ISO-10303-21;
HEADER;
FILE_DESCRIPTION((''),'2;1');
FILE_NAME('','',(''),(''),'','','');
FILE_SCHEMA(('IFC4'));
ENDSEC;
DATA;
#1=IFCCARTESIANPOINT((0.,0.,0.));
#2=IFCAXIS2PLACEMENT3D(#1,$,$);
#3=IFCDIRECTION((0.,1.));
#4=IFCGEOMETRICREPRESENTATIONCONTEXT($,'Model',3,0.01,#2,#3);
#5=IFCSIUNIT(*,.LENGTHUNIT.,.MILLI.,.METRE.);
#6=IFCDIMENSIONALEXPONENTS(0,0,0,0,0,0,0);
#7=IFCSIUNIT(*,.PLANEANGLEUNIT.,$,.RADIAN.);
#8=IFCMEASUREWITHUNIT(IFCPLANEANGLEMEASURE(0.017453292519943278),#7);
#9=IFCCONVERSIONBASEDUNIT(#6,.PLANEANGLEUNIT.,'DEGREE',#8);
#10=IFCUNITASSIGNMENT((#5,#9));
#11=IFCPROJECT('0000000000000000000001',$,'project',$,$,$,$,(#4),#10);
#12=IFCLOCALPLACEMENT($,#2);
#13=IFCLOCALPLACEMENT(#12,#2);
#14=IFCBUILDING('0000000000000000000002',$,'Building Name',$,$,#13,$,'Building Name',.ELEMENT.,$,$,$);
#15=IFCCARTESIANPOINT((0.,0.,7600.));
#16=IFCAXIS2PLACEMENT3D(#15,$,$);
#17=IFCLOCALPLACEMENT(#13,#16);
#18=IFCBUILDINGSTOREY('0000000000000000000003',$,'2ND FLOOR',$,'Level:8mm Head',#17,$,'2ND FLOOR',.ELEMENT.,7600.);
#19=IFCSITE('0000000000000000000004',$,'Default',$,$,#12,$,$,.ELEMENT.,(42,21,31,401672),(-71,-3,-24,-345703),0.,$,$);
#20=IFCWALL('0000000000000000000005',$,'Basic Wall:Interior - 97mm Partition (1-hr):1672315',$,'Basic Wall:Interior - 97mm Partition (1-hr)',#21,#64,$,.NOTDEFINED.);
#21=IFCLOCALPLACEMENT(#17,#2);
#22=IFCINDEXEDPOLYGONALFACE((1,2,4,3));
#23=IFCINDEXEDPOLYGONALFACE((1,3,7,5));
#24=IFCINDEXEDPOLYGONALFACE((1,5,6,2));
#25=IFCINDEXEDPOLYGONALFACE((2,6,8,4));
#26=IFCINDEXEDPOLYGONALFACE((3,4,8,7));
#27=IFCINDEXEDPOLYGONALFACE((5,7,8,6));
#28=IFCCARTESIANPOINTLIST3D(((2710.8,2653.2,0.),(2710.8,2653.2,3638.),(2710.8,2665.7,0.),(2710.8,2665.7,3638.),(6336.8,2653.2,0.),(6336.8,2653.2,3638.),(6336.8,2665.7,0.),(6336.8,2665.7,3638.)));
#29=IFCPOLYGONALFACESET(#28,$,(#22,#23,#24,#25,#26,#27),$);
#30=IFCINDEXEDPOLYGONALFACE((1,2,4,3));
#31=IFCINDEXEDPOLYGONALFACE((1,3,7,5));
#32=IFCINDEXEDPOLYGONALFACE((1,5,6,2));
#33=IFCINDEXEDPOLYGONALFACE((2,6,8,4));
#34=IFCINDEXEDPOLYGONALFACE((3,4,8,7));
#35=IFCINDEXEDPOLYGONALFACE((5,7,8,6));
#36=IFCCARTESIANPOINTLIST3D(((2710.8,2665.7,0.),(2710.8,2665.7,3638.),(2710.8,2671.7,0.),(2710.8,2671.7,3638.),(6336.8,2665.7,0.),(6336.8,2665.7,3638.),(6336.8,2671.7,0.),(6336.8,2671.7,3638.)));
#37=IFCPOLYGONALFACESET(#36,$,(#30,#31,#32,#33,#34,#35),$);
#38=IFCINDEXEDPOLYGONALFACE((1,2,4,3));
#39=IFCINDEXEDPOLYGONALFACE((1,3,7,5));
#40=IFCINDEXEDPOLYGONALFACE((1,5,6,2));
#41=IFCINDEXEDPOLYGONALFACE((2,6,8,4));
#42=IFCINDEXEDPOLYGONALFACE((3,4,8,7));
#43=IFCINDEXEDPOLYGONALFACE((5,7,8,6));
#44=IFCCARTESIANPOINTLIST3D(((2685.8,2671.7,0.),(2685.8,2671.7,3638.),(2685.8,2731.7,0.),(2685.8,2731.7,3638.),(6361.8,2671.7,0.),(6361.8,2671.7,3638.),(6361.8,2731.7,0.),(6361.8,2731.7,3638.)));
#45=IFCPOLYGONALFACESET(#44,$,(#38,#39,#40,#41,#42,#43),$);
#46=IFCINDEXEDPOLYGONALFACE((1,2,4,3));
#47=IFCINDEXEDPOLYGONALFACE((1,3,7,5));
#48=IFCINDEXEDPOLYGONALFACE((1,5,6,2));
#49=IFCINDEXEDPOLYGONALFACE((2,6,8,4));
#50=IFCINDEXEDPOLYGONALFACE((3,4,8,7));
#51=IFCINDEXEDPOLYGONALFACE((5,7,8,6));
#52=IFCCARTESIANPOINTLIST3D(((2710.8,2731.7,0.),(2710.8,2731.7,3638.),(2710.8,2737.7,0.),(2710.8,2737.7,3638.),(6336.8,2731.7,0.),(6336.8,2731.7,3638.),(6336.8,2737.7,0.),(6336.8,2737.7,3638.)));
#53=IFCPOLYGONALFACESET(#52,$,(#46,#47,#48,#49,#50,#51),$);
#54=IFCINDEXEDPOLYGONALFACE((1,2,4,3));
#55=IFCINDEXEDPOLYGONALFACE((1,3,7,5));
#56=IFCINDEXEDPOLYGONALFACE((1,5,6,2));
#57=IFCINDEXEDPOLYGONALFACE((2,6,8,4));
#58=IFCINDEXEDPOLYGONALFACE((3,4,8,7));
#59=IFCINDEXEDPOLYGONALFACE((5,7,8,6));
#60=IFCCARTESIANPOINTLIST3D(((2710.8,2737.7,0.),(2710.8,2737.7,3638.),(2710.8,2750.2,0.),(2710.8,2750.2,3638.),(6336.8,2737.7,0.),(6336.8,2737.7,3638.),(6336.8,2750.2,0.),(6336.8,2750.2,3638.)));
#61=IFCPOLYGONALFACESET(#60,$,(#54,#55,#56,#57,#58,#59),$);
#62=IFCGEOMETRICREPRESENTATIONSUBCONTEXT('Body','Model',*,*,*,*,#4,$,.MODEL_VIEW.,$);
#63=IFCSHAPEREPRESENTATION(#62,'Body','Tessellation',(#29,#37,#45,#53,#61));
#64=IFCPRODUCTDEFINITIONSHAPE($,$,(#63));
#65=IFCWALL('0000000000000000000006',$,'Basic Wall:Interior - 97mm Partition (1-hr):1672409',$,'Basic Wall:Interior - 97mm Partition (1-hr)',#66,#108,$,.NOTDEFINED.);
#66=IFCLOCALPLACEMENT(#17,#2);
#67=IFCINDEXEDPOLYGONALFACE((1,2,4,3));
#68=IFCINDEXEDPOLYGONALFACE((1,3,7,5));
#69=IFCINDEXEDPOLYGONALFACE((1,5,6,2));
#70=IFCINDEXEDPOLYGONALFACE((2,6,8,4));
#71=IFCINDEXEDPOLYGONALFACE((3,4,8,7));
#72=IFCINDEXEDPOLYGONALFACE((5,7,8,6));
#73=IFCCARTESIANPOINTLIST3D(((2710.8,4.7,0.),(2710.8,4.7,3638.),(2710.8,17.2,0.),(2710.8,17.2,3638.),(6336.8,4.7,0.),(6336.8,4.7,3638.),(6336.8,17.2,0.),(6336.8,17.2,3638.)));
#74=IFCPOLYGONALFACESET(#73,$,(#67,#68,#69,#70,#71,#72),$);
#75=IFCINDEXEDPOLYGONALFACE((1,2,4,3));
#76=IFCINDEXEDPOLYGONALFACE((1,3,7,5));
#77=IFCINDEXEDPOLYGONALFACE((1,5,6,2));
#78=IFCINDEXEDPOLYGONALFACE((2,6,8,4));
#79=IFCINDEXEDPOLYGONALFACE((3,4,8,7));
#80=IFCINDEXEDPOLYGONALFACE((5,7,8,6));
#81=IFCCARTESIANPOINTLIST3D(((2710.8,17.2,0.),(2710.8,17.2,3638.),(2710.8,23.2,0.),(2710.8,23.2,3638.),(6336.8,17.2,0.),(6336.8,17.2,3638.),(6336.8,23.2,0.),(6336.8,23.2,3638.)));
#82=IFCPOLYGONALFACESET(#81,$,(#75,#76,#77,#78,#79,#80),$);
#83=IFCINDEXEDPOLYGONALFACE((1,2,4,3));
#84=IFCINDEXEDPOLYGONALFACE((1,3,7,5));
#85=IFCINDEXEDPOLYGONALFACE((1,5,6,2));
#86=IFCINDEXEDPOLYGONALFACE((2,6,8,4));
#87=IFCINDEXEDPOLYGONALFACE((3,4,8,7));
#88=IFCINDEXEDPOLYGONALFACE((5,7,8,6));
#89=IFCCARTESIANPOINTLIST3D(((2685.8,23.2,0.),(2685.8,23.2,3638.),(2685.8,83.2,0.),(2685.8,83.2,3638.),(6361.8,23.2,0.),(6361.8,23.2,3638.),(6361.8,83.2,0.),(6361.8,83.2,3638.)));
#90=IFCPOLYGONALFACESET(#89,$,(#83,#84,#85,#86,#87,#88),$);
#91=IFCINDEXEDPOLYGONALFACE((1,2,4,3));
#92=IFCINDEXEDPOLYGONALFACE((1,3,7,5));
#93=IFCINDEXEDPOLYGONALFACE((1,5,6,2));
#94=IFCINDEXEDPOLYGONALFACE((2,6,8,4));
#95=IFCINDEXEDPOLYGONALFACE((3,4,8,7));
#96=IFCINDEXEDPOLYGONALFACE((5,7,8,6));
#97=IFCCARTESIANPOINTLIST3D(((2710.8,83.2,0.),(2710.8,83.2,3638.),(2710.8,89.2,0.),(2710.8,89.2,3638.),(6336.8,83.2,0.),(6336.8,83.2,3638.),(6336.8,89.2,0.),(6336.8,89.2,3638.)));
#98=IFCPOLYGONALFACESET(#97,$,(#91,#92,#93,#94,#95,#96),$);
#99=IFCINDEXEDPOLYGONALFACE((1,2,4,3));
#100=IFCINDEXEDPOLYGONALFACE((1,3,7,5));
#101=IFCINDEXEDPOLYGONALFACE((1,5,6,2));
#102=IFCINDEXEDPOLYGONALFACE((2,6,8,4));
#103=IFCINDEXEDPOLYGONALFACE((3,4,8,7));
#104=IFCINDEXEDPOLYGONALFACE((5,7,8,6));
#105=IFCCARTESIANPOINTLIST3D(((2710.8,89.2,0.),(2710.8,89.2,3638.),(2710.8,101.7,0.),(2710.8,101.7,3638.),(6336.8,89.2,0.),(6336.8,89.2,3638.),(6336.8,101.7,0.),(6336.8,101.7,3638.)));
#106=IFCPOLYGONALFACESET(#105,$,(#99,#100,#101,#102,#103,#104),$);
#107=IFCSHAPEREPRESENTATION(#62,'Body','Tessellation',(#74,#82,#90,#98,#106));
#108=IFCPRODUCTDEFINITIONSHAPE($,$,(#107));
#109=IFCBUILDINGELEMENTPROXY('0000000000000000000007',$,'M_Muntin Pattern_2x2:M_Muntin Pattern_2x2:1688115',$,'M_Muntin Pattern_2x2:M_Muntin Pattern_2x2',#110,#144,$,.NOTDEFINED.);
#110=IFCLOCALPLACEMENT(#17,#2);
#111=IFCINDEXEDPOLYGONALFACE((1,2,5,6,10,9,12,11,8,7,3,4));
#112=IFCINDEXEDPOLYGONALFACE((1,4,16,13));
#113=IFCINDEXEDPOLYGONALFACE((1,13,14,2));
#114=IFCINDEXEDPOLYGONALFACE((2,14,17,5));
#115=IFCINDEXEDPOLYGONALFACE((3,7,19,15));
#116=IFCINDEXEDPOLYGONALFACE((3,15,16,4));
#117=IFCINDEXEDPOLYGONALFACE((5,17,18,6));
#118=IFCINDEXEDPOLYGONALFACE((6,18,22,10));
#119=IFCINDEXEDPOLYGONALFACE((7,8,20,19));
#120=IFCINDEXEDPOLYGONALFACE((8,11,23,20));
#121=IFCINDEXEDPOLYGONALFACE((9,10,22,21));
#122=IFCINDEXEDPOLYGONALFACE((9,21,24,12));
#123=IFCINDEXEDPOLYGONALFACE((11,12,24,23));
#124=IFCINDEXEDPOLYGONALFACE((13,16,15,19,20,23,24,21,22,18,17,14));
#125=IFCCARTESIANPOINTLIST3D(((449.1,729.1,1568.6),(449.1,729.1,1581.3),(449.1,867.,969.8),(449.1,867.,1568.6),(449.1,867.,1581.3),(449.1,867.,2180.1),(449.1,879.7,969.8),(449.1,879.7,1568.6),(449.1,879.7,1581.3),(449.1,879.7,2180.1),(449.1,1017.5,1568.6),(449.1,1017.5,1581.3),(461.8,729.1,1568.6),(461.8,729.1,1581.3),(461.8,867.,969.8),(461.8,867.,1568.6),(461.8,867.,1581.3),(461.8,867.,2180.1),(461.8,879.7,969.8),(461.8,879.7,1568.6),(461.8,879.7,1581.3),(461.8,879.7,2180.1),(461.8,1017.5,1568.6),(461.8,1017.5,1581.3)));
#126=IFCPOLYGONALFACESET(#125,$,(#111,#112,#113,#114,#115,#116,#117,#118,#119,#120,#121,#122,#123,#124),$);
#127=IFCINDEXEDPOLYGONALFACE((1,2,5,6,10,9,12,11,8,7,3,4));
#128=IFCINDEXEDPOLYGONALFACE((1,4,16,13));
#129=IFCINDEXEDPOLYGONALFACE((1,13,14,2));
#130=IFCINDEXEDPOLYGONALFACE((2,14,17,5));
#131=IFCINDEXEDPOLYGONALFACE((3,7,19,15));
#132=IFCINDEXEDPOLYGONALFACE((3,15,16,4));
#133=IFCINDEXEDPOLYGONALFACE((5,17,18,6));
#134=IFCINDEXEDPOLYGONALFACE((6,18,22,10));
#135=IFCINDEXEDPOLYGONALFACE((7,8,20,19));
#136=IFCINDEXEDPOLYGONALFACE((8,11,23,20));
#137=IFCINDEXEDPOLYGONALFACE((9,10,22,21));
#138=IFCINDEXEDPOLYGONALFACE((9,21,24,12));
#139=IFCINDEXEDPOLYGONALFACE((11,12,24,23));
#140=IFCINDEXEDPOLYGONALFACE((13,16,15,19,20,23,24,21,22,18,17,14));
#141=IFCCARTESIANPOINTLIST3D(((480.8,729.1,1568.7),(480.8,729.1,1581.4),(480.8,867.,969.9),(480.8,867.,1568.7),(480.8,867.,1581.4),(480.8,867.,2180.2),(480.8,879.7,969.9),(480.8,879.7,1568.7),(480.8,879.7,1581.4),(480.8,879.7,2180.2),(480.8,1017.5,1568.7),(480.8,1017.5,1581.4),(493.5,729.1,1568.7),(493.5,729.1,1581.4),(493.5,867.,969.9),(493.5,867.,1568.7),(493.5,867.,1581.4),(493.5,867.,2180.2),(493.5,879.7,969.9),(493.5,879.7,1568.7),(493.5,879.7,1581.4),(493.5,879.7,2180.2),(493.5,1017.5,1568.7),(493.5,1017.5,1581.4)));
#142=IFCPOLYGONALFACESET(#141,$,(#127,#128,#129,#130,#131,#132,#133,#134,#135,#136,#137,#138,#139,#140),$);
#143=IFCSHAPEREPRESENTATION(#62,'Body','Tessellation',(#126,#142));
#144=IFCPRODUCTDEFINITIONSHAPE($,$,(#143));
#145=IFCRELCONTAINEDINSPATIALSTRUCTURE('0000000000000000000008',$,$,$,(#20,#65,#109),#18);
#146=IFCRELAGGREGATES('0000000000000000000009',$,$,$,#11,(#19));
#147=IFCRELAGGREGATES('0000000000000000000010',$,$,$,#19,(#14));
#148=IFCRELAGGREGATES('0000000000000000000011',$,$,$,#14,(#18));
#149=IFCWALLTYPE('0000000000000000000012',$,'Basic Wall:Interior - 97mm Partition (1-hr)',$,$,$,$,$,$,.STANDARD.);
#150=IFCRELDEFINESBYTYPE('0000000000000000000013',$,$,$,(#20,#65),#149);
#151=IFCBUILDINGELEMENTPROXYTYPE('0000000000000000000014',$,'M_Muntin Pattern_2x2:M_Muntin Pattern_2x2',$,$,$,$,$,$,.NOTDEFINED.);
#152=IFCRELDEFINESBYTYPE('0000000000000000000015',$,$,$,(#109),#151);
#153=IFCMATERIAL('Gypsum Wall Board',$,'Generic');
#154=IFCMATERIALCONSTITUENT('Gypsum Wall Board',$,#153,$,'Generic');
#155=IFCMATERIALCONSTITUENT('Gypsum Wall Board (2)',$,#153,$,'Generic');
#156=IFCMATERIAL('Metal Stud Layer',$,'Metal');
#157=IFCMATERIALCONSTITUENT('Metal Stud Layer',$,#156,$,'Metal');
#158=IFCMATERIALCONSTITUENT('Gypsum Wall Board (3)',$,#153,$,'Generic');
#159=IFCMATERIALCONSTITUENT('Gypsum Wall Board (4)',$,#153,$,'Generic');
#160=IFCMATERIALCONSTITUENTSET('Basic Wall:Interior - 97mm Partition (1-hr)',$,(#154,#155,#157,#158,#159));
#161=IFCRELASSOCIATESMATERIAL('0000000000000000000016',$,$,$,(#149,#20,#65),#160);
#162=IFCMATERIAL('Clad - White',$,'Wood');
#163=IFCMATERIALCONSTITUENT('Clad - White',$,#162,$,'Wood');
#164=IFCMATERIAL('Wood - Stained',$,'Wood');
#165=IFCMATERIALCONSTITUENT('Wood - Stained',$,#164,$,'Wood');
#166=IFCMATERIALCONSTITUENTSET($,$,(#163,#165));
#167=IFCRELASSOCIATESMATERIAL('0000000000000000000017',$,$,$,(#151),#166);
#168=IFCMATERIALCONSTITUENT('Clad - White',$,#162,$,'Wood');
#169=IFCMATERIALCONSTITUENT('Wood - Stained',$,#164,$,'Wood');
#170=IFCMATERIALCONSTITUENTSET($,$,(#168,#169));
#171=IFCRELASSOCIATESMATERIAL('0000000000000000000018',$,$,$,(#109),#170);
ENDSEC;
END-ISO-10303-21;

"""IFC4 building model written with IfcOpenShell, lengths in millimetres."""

from ifc_helpers import new_model, entity, si_unit, converted_unit, direction, frame, origin, place, context, subcontext, project, spatial, indexed_curve, outline, extrude, source, transform, mapped, material, constituent, constituent_set, type_object, type_shapes, element, save


model = new_model("IFC4")

# Units and contexts
model_context = context("Model", 3, precision=0.01, world=origin(), true_north=direction((0.0, 1.0)))
body_context = subcontext(model_context, "Body", "Model", "MODEL_VIEW")
ifc_project = project(units=[si_unit("LENGTHUNIT", "METRE", prefix="MILLI"), converted_unit("PLANEANGLEUNIT", "DEGREE", entity("IfcPlaneAngleMeasure", 0.017453292519943278), si_unit("PLANEANGLEUNIT", "RADIAN"), dimensions=[0, 0, 0, 0, 0, 0, 0])], contexts=[model_context])

# Site, building, storey
site_placement = place(None, origin())
site = spatial("IfcSite", under=ifc_project, at=site_placement, Name="Default", CompositionType="ELEMENT", RefLatitude=(42, 21, 31, 401672), RefLongitude=(-71, -3, -24, -345703), RefElevation=0.0)
building_placement = place(site_placement, origin())
building = spatial("IfcBuilding", under=site, at=building_placement, Name="Building Name", LongName="Building Name", CompositionType="ELEMENT")
storey_placement = place(building_placement, frame((0.0, 0.0, 7600.0)))
storey = spatial("IfcBuildingStorey", under=building, at=storey_placement, Name="2ND FLOOR", ObjectType="Level:8mm Head", LongName="2ND FLOOR", CompositionType="ELEMENT", Elevation=7600.0)

# Walls
ifc_material_1 = material(Name="Gypsum Wall Board", Category="Generic")
ifc_constituent_1 = constituent(ifc_material_1, Name="Gypsum Wall Board", Category="Generic")
ifc_constituent_2 = constituent(ifc_material_1, Name="Gypsum Wall Board (2)", Category="Generic")
ifc_material_2 = material(Name="Metal Stud Layer", Category="Metal")
ifc_constituent_3 = constituent(ifc_material_2, Name="Metal Stud Layer", Category="Metal")
ifc_constituent_4 = constituent(ifc_material_1, Name="Gypsum Wall Board (3)", Category="Generic")
ifc_constituent_5 = constituent(ifc_material_1, Name="Gypsum Wall Board (4)", Category="Generic")
ifc_constituent_set_1 = constituent_set(constituents=[ifc_constituent_1, ifc_constituent_2, ifc_constituent_3, ifc_constituent_4, ifc_constituent_5], Name="Basic Wall:Interior - 97mm Partition (1-hr)")
wall_type = type_object("IfcWallType", Name="Basic Wall:Interior - 97mm Partition (1-hr)", PredefinedType="STANDARD", material=ifc_constituent_set_1)
wall_1_placement = place(storey_placement, frame((6336.8, 2701.7, 0.0), z_axis=(0.0, 0.0, 1.0), x_axis=(-1.0, 0.0, 0.0)))
element("IfcWall", 1, at=wall_1_placement, inside=storey, type_object=wall_type, material=ifc_constituent_set_1, Name="Basic Wall:Interior - 97mm Partition (1-hr):1672315", ObjectType="Basic Wall:Interior - 97mm Partition (1-hr)", PredefinedType="NOTDEFINED", context=body_context, shape_type="SweptSolid", body=[
    extrude(outline(indexed_curve([(-6.2, -1813.0), (6.3, -1813.0), (6.2, 1813.0), (-6.3, 1813.0), (-6.2, -1813.0)], self_intersect=False)), frame((1813.0, 42.2, 0.0), z_axis=(0.0, 0.0, 1.0), x_axis=(0.0, -1.0, 0.0)), (0.0, 0.0, 1.0), 3638.0),
    extrude(outline(indexed_curve([(-1813.0, -3.0), (1813.0, -3.0), (1813.0, 3.0), (-1813.0, 3.0), (-1813.0, -3.0)], self_intersect=False)), frame((1813.0, 33.0, 0.0)), (0.0, 0.0, 1.0), 3638.0),
    extrude(outline(indexed_curve([(-1838.0, -30.0), (1838.0, -30.0), (1838.0, 30.0), (-1838.0, 30.0), (-1838.0, -30.0)], self_intersect=False)), frame((1813.0, 0.0, 0.0)), (0.0, 0.0, 1.0), 3638.0),
    extrude(outline(indexed_curve([(-1813.0, -3.0), (1813.0, -3.0), (1813.0, 3.0), (-1813.0, 3.0), (-1813.0, -3.0)], self_intersect=False)), frame((1813.0, -33.0, 0.0)), (0.0, 0.0, 1.0), 3638.0),
    extrude(outline(indexed_curve([(-6.3, -1813.0), (6.3, -1813.0), (6.2, 1813.0), (-6.3, 1813.0), (-6.3, -1813.0)], self_intersect=False)), frame((1813.0, -42.3, 0.0), z_axis=(0.0, 0.0, 1.0), x_axis=(0.0, 1.0, 0.0)), (0.0, 0.0, 1.0), 3638.0),
])
wall_2_placement = place(storey_placement, frame((6336.8, 53.2, 0.0), z_axis=(0.0, 0.0, 1.0), x_axis=(-1.0, 0.0, 0.0)))
element("IfcWall", 2, at=wall_2_placement, inside=storey, type_object=wall_type, material=ifc_constituent_set_1, Name="Basic Wall:Interior - 97mm Partition (1-hr):1672409", ObjectType="Basic Wall:Interior - 97mm Partition (1-hr)", PredefinedType="NOTDEFINED", context=body_context, shape_type="SweptSolid", body=[
    extrude(outline(indexed_curve([(-6.2, -1813.0), (6.3, -1813.0), (6.2, 1813.0), (-6.3, 1813.0), (-6.2, -1813.0)], self_intersect=False)), frame((1813.0, 42.3, 0.0), z_axis=(0.0, 0.0, 1.0), x_axis=(0.0, -1.0, 0.0)), (0.0, 0.0, 1.0), 3638.0),
    extrude(outline(indexed_curve([(-1813.0, -3.0), (1813.0, -3.0), (1813.0, 3.0), (-1813.0, 3.0), (-1813.0, -3.0)], self_intersect=False)), frame((1813.0, 33.0, 0.0)), (0.0, 0.0, 1.0), 3638.0),
    extrude(outline(indexed_curve([(-1838.0, -30.0), (1838.0, -30.0), (1838.0, 30.0), (-1838.0, 30.0), (-1838.0, -30.0)], self_intersect=False)), frame((1813.0, 0.0, 0.0)), (0.0, 0.0, 1.0), 3638.0),
    extrude(outline(indexed_curve([(-1813.0, -3.0), (1813.0, -3.0), (1813.0, 3.0), (-1813.0, 3.0), (-1813.0, -3.0)], self_intersect=False)), frame((1813.0, -33.0, 0.0)), (0.0, 0.0, 1.0), 3638.0),
    extrude(outline(indexed_curve([(-6.2, -1813.0), (6.3, -1813.0), (6.2, 1813.0), (-6.3, 1813.0), (-6.2, -1813.0)], self_intersect=False)), frame((1813.0, -42.2, 0.0), z_axis=(0.0, 0.0, 1.0), x_axis=(0.0, 1.0, 0.0)), (0.0, 0.0, 1.0), 3638.0),
])

# Building element proxy
ifc_material_3 = material(Name="Clad - White", Category="Wood")
ifc_constituent_6 = constituent(ifc_material_3, Name="Clad - White", Category="Wood")
ifc_material_4 = material(Name="Wood - Stained", Category="Wood")
ifc_constituent_7 = constituent(ifc_material_4, Name="Wood - Stained", Category="Wood")
ifc_constituent_set_2 = constituent_set(constituents=[ifc_constituent_6, ifc_constituent_7])
ifc_constituent_8 = constituent(ifc_material_3, Name="Clad - White", Category="Wood")
ifc_constituent_9 = constituent(ifc_material_4, Name="Wood - Stained", Category="Wood")
ifc_constituent_set_3 = constituent_set(constituents=[ifc_constituent_8, ifc_constituent_9])
building_element_proxy_type_1 = type_object("IfcBuildingElementProxyType", Name="M_Muntin Pattern_2x2:M_Muntin Pattern_2x2", PredefinedType="NOTDEFINED", material=ifc_constituent_set_3)
shared_shape_1 = source(origin(), body_context, "Body", "SweptSolid", [
    extrude(outline(indexed_curve([(6.4, -6.4), (605.1, -6.4), (605.1, 6.3), (6.4, 6.3), (6.4, 144.2), (-6.3, 144.2), (-6.3, 6.3), (-605.2, 6.3), (-605.2, -6.4), (-6.3, -6.4), (-6.3, -144.2), (6.4, -144.2), (6.4, -6.4)], self_intersect=False)), frame((0.0, -22.2, 605.1), z_axis=(0.0, 1.0, 0.0), x_axis=(0.0, 0.0, 1.0)), (0.0, 0.0, 1.0), 12.7),
    extrude(outline(indexed_curve([(6.4, -6.4), (605.2, -6.4), (605.2, 6.3), (6.4, 6.3), (6.4, 144.2), (-6.3, 144.2), (-6.3, 6.3), (-605.2, 6.3), (-605.2, -6.4), (-6.3, -6.4), (-6.3, -144.2), (6.4, -144.2), (6.4, -6.4)], self_intersect=False)), frame((0.0, 9.5, 605.2), z_axis=(0.0, 1.0, 0.0), x_axis=(0.0, 0.0, 1.0)), (0.0, 0.0, 1.0), 12.7),
])
type_shapes(building_element_proxy_type_1, [shared_shape_1])
proxy_1_placement = place(storey_placement, frame((471.3, 873.3, 969.9), z_axis=(0.0, 0.0, 1.0), x_axis=(0.0, -1.0, 0.0)))
element("IfcBuildingElementProxy", 3, at=proxy_1_placement, inside=storey, type_object=building_element_proxy_type_1, material=ifc_constituent_set_2, Name="M_Muntin Pattern_2x2:M_Muntin Pattern_2x2:1688115", ObjectType="M_Muntin Pattern_2x2:M_Muntin Pattern_2x2", PredefinedType="NOTDEFINED", context=body_context, shape_type="MappedRepresentation", body=[
    mapped(shared_shape_1, transform((0.0, 0.0, 0.0), scale=1.0)),
])

save(model, "model.ifc")
